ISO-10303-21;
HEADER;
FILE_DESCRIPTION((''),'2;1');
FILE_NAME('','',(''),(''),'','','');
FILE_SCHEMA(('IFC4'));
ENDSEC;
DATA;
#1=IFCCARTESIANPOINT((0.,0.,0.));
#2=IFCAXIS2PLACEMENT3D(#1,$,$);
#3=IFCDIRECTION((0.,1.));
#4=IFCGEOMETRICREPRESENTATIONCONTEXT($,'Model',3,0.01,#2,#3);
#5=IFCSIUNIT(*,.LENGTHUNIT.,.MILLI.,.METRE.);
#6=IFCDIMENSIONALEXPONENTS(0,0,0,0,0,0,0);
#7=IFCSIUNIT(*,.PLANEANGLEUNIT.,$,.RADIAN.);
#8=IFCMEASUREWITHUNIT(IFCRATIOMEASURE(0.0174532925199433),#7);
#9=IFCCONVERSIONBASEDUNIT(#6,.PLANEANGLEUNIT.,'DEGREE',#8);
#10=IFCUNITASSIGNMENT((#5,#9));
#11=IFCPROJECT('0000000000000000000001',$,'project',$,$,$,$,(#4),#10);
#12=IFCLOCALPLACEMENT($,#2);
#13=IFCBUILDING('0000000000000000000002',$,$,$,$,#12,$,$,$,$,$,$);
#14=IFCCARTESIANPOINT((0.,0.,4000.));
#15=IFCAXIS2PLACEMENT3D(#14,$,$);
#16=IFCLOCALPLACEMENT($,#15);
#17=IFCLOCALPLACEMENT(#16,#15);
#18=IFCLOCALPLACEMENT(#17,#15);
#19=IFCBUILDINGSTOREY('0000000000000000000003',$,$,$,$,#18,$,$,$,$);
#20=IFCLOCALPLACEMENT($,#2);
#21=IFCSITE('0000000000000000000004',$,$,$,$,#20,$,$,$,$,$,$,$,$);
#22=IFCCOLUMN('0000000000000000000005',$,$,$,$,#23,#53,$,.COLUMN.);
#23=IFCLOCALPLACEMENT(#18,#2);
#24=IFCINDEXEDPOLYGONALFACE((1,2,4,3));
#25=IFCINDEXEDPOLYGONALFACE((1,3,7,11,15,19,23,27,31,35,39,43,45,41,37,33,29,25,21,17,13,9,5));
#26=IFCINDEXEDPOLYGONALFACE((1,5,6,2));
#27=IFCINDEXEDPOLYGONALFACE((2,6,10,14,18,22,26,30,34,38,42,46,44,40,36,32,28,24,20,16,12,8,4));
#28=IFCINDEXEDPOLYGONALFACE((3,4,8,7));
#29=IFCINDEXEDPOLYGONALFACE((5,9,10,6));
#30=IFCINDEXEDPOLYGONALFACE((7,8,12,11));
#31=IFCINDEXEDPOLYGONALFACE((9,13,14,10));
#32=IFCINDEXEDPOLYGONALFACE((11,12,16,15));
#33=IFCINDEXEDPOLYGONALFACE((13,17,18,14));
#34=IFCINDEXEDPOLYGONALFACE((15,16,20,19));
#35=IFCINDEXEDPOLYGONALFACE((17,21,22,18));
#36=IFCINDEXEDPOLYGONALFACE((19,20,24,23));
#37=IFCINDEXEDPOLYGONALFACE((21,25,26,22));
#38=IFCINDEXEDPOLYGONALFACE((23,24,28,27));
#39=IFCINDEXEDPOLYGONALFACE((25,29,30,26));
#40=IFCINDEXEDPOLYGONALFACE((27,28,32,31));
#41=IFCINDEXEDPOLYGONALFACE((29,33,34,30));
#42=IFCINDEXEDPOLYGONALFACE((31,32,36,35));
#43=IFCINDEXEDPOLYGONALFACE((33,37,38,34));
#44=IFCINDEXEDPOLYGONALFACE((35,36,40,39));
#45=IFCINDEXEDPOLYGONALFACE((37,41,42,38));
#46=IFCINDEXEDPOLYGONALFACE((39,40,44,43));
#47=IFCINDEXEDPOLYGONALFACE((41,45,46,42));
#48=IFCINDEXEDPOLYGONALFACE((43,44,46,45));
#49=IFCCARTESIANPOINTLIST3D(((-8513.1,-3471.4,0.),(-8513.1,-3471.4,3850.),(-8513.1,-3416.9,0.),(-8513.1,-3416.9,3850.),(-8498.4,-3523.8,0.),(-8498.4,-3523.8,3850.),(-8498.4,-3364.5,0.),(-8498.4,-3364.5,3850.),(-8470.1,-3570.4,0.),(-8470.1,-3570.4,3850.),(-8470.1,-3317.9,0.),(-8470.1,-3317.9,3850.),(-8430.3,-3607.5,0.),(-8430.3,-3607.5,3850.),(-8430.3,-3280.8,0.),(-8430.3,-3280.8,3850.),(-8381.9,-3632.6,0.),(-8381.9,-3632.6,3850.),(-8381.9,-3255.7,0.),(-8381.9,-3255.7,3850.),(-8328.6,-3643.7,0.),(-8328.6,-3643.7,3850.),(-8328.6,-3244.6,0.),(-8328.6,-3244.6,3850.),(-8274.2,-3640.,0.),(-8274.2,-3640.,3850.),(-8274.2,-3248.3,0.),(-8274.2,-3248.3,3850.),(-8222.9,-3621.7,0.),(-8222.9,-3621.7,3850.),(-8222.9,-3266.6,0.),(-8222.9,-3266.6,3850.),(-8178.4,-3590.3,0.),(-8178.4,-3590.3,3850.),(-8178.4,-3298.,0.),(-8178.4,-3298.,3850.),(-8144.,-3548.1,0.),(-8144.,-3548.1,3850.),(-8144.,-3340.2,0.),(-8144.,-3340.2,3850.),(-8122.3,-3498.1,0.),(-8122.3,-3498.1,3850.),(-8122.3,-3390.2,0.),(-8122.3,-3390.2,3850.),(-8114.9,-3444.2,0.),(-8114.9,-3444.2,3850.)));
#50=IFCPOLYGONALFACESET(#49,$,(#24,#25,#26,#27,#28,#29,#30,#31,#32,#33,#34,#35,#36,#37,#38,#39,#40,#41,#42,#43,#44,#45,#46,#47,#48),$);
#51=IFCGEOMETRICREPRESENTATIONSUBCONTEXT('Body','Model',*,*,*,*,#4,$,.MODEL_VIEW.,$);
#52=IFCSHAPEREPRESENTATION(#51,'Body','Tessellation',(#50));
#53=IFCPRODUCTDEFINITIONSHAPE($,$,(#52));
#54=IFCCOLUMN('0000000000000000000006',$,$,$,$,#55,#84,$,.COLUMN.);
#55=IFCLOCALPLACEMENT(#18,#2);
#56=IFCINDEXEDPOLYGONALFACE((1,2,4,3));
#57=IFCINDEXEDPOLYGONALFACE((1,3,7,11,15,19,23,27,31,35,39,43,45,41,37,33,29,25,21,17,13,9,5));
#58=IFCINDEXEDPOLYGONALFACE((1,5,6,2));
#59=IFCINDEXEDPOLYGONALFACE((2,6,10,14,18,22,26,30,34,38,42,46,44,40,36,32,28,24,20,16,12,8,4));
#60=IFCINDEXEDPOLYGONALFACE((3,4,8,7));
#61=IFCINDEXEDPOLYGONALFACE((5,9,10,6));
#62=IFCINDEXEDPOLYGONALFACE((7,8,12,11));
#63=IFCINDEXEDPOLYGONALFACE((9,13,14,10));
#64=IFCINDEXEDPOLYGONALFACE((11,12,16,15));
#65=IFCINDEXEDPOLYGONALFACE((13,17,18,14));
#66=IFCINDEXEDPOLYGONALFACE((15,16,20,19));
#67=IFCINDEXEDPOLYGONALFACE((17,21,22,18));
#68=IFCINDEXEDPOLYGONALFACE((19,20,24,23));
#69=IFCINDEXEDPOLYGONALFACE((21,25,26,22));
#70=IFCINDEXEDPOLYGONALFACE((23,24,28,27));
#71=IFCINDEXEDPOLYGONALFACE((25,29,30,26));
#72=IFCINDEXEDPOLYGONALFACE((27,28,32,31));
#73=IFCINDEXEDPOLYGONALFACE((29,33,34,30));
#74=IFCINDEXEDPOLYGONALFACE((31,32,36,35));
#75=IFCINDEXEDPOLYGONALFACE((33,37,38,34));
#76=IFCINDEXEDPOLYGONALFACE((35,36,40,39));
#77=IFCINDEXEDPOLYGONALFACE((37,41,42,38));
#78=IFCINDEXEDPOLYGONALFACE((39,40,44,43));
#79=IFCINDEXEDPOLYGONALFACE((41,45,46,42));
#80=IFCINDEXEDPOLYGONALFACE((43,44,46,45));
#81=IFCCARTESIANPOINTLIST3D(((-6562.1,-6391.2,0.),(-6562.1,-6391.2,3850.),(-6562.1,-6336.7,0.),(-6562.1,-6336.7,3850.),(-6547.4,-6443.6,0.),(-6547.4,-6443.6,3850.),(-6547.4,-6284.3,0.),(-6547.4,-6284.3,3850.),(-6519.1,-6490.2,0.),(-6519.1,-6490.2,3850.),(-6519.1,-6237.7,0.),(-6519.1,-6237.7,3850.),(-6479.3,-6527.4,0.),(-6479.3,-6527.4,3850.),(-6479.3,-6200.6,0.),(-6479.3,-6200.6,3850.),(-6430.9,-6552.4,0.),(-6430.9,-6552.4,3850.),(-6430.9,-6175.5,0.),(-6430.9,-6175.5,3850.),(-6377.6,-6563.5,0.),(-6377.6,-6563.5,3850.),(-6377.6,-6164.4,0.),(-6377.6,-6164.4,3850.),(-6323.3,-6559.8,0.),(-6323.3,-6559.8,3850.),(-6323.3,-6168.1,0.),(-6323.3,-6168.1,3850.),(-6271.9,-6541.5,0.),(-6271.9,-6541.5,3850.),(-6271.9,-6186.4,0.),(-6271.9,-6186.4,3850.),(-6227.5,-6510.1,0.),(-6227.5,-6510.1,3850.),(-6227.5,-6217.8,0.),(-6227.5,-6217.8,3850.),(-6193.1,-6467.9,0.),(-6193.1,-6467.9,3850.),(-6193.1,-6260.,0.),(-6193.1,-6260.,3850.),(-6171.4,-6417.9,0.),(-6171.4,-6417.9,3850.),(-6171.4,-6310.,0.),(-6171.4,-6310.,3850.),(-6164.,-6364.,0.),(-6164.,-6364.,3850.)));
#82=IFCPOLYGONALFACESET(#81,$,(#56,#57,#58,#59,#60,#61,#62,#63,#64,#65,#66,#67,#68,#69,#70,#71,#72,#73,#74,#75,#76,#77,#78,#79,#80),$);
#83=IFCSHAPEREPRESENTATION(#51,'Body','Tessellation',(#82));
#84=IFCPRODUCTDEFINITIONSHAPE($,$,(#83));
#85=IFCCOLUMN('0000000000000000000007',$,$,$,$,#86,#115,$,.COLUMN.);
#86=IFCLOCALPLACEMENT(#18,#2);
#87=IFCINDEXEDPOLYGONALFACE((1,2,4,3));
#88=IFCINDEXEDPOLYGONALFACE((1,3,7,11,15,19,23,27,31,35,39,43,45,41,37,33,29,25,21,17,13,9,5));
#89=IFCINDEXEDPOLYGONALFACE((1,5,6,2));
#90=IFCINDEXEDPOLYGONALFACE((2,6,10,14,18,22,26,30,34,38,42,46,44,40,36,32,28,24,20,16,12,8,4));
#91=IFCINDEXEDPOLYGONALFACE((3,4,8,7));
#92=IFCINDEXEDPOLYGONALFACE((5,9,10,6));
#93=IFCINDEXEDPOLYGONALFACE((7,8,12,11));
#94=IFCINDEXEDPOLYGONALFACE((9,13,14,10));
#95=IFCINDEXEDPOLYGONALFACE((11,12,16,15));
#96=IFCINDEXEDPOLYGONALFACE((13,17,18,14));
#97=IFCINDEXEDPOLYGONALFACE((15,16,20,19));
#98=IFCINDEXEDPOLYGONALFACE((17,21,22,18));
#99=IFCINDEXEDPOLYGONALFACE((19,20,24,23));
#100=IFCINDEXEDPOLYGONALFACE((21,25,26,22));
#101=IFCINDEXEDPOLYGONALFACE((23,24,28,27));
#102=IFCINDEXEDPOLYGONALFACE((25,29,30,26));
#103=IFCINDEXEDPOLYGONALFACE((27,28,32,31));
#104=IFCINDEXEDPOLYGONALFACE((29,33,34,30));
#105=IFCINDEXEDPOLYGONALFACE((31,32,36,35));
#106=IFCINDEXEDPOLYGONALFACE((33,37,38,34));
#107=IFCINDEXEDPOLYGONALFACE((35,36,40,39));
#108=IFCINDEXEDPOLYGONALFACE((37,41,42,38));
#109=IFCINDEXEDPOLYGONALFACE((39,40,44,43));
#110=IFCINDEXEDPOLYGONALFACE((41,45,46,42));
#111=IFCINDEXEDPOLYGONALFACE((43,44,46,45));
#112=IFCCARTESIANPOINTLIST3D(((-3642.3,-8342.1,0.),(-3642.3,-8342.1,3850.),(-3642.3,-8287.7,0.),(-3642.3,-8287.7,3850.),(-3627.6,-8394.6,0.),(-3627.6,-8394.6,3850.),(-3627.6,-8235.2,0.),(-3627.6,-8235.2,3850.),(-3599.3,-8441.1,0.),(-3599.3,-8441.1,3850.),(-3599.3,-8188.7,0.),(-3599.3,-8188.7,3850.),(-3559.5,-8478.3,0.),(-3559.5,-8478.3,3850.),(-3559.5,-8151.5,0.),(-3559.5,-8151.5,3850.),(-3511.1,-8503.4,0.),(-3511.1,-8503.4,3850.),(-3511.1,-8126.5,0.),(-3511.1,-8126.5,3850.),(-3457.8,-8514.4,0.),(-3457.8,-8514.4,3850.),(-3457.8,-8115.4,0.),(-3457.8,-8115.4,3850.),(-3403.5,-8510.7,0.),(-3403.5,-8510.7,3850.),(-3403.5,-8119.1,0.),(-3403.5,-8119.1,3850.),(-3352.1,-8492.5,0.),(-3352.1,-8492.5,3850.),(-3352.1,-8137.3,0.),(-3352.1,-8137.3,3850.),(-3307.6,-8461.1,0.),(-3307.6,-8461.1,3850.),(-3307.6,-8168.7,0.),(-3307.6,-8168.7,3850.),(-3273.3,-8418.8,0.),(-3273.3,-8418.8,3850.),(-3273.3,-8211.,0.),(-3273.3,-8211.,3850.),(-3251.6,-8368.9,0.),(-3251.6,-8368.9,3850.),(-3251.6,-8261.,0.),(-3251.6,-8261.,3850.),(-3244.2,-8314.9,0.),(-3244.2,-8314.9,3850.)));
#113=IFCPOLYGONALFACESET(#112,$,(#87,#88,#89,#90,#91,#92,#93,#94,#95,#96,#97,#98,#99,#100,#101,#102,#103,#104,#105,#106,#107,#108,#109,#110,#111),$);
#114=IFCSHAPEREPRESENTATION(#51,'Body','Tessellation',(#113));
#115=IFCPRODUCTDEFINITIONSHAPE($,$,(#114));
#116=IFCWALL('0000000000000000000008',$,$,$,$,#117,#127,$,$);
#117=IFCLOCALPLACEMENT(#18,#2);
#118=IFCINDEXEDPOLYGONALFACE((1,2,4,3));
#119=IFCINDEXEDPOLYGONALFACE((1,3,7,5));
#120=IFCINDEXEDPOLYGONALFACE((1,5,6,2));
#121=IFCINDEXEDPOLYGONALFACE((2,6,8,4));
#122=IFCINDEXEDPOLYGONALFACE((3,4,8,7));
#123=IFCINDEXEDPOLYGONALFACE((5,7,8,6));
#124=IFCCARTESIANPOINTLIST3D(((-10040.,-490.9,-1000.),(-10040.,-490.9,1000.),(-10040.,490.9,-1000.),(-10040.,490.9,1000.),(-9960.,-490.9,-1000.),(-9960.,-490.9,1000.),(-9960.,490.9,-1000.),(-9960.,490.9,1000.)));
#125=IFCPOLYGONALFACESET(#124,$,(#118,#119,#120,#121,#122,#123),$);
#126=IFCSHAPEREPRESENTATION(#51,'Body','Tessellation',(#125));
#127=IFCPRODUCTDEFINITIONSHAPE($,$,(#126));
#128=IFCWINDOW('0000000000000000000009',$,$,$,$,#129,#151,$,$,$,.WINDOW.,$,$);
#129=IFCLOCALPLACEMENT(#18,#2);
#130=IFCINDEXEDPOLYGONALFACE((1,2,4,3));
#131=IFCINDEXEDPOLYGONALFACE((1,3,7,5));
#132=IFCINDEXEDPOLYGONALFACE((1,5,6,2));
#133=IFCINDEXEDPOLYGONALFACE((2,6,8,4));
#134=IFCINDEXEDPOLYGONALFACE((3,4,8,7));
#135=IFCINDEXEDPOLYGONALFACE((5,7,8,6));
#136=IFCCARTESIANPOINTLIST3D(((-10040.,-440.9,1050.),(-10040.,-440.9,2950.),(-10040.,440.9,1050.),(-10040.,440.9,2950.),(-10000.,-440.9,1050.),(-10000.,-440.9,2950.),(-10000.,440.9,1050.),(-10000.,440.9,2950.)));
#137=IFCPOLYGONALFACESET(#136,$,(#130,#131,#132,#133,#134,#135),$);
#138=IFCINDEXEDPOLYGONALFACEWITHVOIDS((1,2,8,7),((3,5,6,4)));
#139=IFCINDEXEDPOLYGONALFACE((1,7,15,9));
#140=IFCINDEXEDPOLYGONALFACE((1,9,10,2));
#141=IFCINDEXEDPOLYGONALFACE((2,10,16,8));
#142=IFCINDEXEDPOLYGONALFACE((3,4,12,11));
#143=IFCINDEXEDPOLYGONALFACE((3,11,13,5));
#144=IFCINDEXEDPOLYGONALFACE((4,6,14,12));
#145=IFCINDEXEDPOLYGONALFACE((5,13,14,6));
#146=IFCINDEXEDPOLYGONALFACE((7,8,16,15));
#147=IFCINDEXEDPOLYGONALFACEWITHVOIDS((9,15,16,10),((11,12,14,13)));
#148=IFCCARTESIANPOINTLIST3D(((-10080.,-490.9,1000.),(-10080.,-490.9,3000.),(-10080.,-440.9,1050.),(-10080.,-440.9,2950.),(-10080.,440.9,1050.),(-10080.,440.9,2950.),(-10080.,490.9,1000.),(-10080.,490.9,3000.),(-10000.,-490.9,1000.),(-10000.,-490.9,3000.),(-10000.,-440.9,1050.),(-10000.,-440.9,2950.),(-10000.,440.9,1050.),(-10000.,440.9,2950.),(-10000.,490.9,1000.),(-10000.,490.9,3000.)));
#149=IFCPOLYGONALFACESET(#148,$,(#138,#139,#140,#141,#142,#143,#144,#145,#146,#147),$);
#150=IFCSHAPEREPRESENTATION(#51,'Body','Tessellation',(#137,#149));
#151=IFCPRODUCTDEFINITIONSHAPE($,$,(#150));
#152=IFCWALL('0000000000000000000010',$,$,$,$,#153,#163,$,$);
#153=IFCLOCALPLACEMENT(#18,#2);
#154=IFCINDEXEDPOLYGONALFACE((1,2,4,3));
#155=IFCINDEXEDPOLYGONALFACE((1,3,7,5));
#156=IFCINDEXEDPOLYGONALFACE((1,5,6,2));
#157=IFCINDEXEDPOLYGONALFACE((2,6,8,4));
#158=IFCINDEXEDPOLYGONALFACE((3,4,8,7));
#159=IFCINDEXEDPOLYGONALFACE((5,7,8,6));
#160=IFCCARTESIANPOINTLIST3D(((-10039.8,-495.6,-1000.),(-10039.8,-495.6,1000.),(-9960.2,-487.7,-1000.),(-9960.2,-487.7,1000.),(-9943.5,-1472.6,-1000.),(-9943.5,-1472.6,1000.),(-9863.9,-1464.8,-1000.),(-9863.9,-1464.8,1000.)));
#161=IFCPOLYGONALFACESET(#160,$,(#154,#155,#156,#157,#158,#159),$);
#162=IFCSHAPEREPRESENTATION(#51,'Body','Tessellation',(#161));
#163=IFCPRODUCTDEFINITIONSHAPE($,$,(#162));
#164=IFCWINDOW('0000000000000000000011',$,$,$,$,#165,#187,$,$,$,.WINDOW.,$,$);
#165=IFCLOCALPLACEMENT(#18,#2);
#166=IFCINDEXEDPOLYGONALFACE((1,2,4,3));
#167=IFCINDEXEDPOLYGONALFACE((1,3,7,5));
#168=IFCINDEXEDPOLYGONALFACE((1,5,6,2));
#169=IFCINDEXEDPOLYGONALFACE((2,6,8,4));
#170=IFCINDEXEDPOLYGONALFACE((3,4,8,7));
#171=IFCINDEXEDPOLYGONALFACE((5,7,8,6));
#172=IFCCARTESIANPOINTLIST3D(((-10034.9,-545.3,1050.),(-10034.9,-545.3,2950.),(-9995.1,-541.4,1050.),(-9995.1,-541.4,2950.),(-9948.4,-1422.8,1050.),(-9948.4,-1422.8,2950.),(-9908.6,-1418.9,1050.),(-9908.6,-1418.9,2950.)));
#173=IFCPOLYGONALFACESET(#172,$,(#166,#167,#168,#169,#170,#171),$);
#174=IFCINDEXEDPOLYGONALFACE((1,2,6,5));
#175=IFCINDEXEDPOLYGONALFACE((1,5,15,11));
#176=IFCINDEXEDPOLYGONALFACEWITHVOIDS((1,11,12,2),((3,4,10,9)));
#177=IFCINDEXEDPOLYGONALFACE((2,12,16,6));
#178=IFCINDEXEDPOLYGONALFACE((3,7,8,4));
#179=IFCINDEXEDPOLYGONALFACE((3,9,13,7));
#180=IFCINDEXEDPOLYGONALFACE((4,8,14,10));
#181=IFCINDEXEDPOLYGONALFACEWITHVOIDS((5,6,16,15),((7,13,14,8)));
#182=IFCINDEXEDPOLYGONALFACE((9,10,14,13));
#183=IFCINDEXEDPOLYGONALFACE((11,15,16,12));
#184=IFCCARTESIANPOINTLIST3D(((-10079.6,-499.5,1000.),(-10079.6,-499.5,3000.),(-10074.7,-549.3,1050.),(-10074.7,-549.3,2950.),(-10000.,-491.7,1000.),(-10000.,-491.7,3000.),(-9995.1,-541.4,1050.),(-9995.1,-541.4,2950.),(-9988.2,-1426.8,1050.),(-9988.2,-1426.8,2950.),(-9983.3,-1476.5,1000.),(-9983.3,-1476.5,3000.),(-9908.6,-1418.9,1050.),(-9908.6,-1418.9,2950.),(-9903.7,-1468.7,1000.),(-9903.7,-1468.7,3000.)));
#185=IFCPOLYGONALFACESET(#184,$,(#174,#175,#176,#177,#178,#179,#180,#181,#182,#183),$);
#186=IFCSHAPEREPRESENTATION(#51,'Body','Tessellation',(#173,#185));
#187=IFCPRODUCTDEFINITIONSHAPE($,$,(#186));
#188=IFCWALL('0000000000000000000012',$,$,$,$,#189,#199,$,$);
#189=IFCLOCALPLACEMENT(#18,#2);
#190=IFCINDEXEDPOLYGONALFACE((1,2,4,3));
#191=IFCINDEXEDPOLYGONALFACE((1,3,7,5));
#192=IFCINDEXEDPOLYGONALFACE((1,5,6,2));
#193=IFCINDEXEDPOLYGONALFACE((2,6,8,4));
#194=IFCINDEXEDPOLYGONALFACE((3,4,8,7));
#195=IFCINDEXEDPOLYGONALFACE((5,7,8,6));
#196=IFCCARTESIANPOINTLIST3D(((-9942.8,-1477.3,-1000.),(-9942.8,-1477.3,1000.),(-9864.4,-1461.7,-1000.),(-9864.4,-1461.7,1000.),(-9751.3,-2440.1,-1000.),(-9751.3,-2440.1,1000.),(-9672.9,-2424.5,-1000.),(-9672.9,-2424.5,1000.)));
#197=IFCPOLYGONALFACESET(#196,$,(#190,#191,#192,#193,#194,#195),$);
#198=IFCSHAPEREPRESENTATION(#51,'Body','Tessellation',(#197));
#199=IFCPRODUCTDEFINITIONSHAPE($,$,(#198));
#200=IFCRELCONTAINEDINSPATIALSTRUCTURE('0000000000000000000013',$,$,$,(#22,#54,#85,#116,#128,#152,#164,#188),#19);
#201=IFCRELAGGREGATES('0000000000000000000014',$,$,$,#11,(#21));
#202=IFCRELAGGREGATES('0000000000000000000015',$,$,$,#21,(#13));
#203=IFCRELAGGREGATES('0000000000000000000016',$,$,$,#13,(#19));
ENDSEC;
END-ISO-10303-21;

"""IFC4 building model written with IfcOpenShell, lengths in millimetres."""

from ifc_helpers import new_model, entity, si_unit, converted_unit, direction, frame, origin, origin_2d, place, context, subcontext, project, spatial, rectangle, circle, extrude, element, save


model = new_model("IFC4")

# Units and contexts
model_context = context("Model", 3, precision=0.01, world=origin(), true_north=direction((0.0, 1.0)))
body_context = subcontext(model_context, "Body", "Model", "MODEL_VIEW")
ifc_project = project(units=[si_unit("LENGTHUNIT", "METRE", prefix="MILLI"), converted_unit("PLANEANGLEUNIT", "DEGREE", entity("IfcRatioMeasure", 0.0174532925199433), si_unit("PLANEANGLEUNIT", "RADIAN"), dimensions=[0, 0, 0, 0, 0, 0, 0])], contexts=[model_context])

# Site, building, storey
site_placement = place(None, origin())
site = spatial("IfcSite", under=ifc_project, at=site_placement)
building_placement = place(None, origin())
building = spatial("IfcBuilding", under=site, at=building_placement)
placement_1 = place(None, frame((0.0, 0.0, 4000.0)))
placement_2 = place(placement_1, frame((0.0, 0.0, 4000.0)))
storey_placement = place(placement_2, frame((0.0, 0.0, 4000.0)))
storey = spatial("IfcBuildingStorey", under=building, at=storey_placement)

# Columns
for number, where in (
    (1, (-8314.9, -3444.2, 0.0)),
    (2, (-6364.0, -6364.0, 0.0)),
    (3, (-3444.2, -8314.9, 0.0)),
):
    element("IfcColumn", number, at=place(storey_placement, frame(where)), inside=storey, PredefinedType="COLUMN", context=body_context, shape_type="SweptSolid", body=[
        extrude(circle(Radius=200.0, at=origin_2d()), origin(), (0.0, 0.0, 1.0), 3850.0),
    ])

# Wall
wall_1_placement = place(storey_placement, frame((-10000.0, 0.0, -1000.0), z_axis=(0.0, 0.0, 1.0), x_axis=(0.000874, -10000.0, 0.0)))
element("IfcWall", 4, at=wall_1_placement, inside=storey, context=body_context, shape_type="SweptSolid", body=[
    extrude(rectangle(XDim=981.7, YDim=80.0, at=origin_2d()), origin(), (0.0, 0.0, 1.0), 2000.0),
])

# Window
cartesian_point_1 = entity("IfcCartesianPoint", [-440.9, -950.0])
shared_polyline = entity("IfcPolyline", [cartesian_point_1, entity("IfcCartesianPoint", [-440.9, 950.0]), entity("IfcCartesianPoint", [-440.9, 950.0]), entity("IfcCartesianPoint", [440.9, 950.0]), entity("IfcCartesianPoint", [440.9, 950.0]), entity("IfcCartesianPoint", [440.9, -950.0]), entity("IfcCartesianPoint", [440.9, -950.0]), entity("IfcCartesianPoint", [-440.9, -950.0]), cartesian_point_1])
window_1_placement = place(storey_placement, frame((-10000.0, 0.0, 2000.0), z_axis=(0.0, 0.0, 1.0), x_axis=(0.000874, -10000.0, 0.0)))
cartesian_point_2 = entity("IfcCartesianPoint", [-490.9, -1000.0])
element("IfcWindow", 5, at=window_1_placement, inside=storey, PredefinedType="WINDOW", context=body_context, shape_type="SweptSolid", body=[
    entity("IfcExtrudedAreaSolid", entity("IfcArbitraryClosedProfileDef", "AREA", None, shared_polyline), entity("IfcAxis2Placement3D", entity("IfcCartesianPoint", [0.0, 0.0, 0.0]), entity("IfcDirection", [0.0, -1.0, 0.0]), entity("IfcDirection", [1.0, 0.0, 0.0])), entity("IfcDirection", [0.0, 0.0, 1.0]), 40.0),
    entity("IfcExtrudedAreaSolid", entity("IfcArbitraryProfileDefWithVoids", "AREA", None, entity("IfcPolyline", [cartesian_point_2, entity("IfcCartesianPoint", [-490.9, 1000.0]), entity("IfcCartesianPoint", [-490.9, 1000.0]), entity("IfcCartesianPoint", [490.9, 1000.0]), entity("IfcCartesianPoint", [490.9, 1000.0]), entity("IfcCartesianPoint", [490.9, -1000.0]), entity("IfcCartesianPoint", [490.9, -1000.0]), entity("IfcCartesianPoint", [-490.9, -1000.0]), cartesian_point_2]), [shared_polyline]), entity("IfcAxis2Placement3D", entity("IfcCartesianPoint", [0.0, 0.0, 0.0]), entity("IfcDirection", [0.0, -1.0, 0.0]), entity("IfcDirection", [1.0, 0.0, 0.0])), entity("IfcDirection", [0.0, 0.0, 1.0]), 80.0),
])

# Wall
wall_2_placement = place(storey_placement, frame((-9951.8, -980.2, -1000.0), z_axis=(0.0, 0.0, 1.0), x_axis=(980.170299, -9951.847376, 0.0)))
element("IfcWall", 6, at=wall_2_placement, inside=storey, context=body_context, shape_type="SweptSolid", body=[
    extrude(rectangle(XDim=981.7, YDim=80.0, at=origin_2d()), origin(), (0.0, 0.0, 1.0), 2000.0),
])

# Window
window_2_placement = place(storey_placement, frame((-9951.8, -980.2, 2000.0), z_axis=(0.0, 0.0, 1.0), x_axis=(980.170299, -9951.847376, 0.0)))
cartesian_point_3 = entity("IfcCartesianPoint", [-490.9, -1000.0])
element("IfcWindow", 7, at=window_2_placement, inside=storey, PredefinedType="WINDOW", context=body_context, shape_type="SweptSolid", body=[
    entity("IfcExtrudedAreaSolid", entity("IfcArbitraryClosedProfileDef", "AREA", None, shared_polyline), entity("IfcAxis2Placement3D", entity("IfcCartesianPoint", [0.0, 0.0, 0.0]), entity("IfcDirection", [0.0, -1.0, 0.0]), entity("IfcDirection", [1.0, 0.0, 0.0])), entity("IfcDirection", [0.0, 0.0, 1.0]), 40.0),
    entity("IfcExtrudedAreaSolid", entity("IfcArbitraryProfileDefWithVoids", "AREA", None, entity("IfcPolyline", [cartesian_point_3, entity("IfcCartesianPoint", [-490.9, 1000.0]), entity("IfcCartesianPoint", [-490.9, 1000.0]), entity("IfcCartesianPoint", [490.9, 1000.0]), entity("IfcCartesianPoint", [490.9, 1000.0]), entity("IfcCartesianPoint", [490.9, -1000.0]), entity("IfcCartesianPoint", [490.9, -1000.0]), entity("IfcCartesianPoint", [-490.9, -1000.0]), cartesian_point_3]), [shared_polyline]), entity("IfcAxis2Placement3D", entity("IfcCartesianPoint", [0.0, 0.0, 0.0]), entity("IfcDirection", [0.0, -1.0, 0.0]), entity("IfcDirection", [1.0, 0.0, 0.0])), entity("IfcDirection", [0.0, 0.0, 1.0]), 80.0),
])

# Wall
wall_3_placement = place(storey_placement, frame((-9807.9, -1950.9, -1000.0), z_axis=(0.0, 0.0, 1.0), x_axis=(1950.902524, -9807.852943, 0.0)))
element("IfcWall", 8, at=wall_3_placement, inside=storey, context=body_context, shape_type="SweptSolid", body=[
    extrude(rectangle(XDim=981.7, YDim=80.0, at=origin_2d()), origin(), (0.0, 0.0, 1.0), 2000.0),
])

save(model, "model.ifc")
